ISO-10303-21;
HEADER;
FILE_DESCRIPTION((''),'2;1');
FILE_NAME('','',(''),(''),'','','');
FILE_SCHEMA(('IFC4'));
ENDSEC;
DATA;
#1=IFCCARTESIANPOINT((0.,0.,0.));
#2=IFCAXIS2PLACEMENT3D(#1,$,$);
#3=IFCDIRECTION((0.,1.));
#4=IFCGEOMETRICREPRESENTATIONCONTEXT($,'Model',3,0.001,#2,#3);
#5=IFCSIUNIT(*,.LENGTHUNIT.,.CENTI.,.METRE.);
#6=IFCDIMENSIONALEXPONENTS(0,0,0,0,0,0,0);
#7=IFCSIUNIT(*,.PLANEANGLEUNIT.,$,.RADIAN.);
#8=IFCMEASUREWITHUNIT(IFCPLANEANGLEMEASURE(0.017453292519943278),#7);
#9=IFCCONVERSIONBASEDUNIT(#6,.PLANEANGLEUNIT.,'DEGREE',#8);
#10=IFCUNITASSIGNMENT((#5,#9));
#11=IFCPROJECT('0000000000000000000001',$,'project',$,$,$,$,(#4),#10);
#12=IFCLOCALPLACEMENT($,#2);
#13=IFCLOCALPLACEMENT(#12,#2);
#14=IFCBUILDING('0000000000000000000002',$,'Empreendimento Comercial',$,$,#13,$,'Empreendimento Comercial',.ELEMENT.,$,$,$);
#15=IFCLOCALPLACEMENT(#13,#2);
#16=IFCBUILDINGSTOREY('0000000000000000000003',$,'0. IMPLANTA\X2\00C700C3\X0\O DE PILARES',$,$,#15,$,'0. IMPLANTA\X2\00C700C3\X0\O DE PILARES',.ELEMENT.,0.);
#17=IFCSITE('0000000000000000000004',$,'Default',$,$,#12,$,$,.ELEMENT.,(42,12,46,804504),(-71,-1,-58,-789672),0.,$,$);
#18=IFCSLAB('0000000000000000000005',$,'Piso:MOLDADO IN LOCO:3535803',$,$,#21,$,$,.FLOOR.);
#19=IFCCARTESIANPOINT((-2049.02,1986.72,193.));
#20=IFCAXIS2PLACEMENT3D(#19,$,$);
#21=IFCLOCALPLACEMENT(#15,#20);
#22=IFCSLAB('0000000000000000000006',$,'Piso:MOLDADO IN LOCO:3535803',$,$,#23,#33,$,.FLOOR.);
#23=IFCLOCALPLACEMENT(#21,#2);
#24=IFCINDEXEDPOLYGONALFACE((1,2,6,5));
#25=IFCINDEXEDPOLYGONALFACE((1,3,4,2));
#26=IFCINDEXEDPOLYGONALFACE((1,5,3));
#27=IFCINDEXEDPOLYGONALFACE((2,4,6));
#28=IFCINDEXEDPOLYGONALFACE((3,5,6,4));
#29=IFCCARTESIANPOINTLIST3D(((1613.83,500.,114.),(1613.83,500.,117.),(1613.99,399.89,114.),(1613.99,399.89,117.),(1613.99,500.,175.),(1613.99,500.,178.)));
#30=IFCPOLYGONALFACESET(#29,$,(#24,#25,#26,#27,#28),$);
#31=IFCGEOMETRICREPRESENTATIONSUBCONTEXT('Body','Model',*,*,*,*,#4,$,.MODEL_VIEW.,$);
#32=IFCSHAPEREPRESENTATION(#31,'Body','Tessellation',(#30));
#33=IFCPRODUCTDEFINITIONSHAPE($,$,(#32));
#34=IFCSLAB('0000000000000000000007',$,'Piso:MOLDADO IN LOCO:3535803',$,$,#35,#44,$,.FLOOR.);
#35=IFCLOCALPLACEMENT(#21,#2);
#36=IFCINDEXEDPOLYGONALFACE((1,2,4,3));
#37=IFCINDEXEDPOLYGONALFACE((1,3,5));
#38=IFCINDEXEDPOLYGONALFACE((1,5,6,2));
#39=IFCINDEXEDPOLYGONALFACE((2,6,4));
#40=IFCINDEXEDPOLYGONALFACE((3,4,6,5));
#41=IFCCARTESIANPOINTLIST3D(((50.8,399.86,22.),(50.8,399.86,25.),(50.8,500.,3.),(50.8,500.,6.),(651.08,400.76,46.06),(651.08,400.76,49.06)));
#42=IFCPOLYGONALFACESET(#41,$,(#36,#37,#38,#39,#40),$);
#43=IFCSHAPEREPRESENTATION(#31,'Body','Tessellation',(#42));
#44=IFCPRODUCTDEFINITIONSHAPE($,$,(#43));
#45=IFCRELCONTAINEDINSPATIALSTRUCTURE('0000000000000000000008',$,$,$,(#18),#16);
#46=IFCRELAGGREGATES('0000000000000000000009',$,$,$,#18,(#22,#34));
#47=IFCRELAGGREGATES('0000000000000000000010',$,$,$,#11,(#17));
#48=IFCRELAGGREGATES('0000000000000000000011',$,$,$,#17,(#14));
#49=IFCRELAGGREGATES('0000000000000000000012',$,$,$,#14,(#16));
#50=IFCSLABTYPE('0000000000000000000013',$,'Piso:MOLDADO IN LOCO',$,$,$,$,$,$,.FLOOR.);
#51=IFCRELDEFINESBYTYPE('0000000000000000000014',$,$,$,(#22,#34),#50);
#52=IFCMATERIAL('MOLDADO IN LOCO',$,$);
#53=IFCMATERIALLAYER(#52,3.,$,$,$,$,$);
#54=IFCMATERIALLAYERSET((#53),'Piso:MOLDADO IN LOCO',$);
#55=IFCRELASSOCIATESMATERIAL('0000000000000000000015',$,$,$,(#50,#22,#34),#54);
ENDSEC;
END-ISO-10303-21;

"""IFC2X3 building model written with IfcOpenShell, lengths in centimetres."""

from ifc_helpers import new_model, entity, si_unit, converted_unit, direction, frame, origin, place, context, subcontext, project, spatial, polyline, outline, extrude, material, layer, layer_set, type_object, element, aggregate, save


model = new_model("IFC2X3")

# Units and contexts
model_context = context("Model", 3, precision=0.001, world=origin(), true_north=direction((0.0, 1.0)))
body_context = subcontext(model_context, "Body", "Model", "MODEL_VIEW")
ifc_project = project(units=[si_unit("LENGTHUNIT", "METRE", prefix="CENTI"), converted_unit("PLANEANGLEUNIT", "DEGREE", entity("IfcPlaneAngleMeasure", 0.017453292519943278), si_unit("PLANEANGLEUNIT", "RADIAN"), dimensions=[0, 0, 0, 0, 0, 0, 0])], contexts=[model_context])

# Site, building, storey
site_placement = place(None, origin())
site = spatial("IfcSite", under=ifc_project, at=site_placement, Name="Default", CompositionType="ELEMENT", RefLatitude=(42, 12, 46, 804504), RefLongitude=(-71, -1, -58, -789672), RefElevation=0.0)
building_placement = place(site_placement, origin())
building = spatial("IfcBuilding", under=site, at=building_placement, Name="Empreendimento Comercial", LongName="Empreendimento Comercial", CompositionType="ELEMENT")
storey_placement = place(building_placement, origin())
storey = spatial("IfcBuildingStorey", under=building, at=storey_placement, Name="0. IMPLANTAÇÃO DE PILARES", LongName="0. IMPLANTAÇÃO DE PILARES", CompositionType="ELEMENT", Elevation=0.0)

# Slabs
slab_1_placement = place(storey_placement, frame((-2049.02, 1986.72, 193.0)))
slab_1 = element("IfcSlab", 1, at=slab_1_placement, inside=storey, Name="Piso:MOLDADO IN LOCO:3535803", PredefinedType="FLOOR")
ifc_material_1 = material(Name="MOLDADO IN LOCO")
ifc_layer = layer(ifc_material_1, 3.0)
ifc_layer_set = layer_set([ifc_layer], Name="Piso:MOLDADO IN LOCO")
slab_type = type_object("IfcSlabType", Name="Piso:MOLDADO IN LOCO", PredefinedType="FLOOR", material=ifc_layer_set)
slab_2_placement = place(slab_1_placement, origin())
slab_2 = element("IfcSlab", 2, at=slab_2_placement, type_object=slab_type, material=ifc_layer_set, Name="Piso:MOLDADO IN LOCO:3535803", PredefinedType="FLOOR", context=body_context, shape_type="SweptSolid", body=[
    extrude(outline(polyline([(0.0, 58.62), (-52.09, 26.88), (0.0, -58.62), (0.0, 58.62)])), frame((1613.99, 449.94, 147.5), z_axis=(-0.999995, -0.001696, 0.002783), x_axis=(0.003259, -0.520325, 0.853962)), (-0.853962, -0.520328, -0.002783), 3.0),
])
slab_3_placement = place(slab_1_placement, origin())
slab_3 = element("IfcSlab", 3, at=slab_3_placement, type_object=slab_type, material=ifc_layer_set, Name="Piso:MOLDADO IN LOCO:3535803", PredefinedType="FLOOR", context=body_context, shape_type="SweptSolid", body=[
    extrude(outline(polyline([(-300.38, 52.77), (-300.38, -49.16), (300.38, -52.77), (-300.38, 52.77)])), frame((350.94, 450.38, 27.53), z_axis=(-0.039622, 0.186261, 0.981701), x_axis=(0.999215, 0.007386, 0.038928)), (-0.038928, 0.186407, -0.981701), 3.0),
])
aggregate(slab_1, [slab_2, slab_3])

save(model, "model.ifc")
